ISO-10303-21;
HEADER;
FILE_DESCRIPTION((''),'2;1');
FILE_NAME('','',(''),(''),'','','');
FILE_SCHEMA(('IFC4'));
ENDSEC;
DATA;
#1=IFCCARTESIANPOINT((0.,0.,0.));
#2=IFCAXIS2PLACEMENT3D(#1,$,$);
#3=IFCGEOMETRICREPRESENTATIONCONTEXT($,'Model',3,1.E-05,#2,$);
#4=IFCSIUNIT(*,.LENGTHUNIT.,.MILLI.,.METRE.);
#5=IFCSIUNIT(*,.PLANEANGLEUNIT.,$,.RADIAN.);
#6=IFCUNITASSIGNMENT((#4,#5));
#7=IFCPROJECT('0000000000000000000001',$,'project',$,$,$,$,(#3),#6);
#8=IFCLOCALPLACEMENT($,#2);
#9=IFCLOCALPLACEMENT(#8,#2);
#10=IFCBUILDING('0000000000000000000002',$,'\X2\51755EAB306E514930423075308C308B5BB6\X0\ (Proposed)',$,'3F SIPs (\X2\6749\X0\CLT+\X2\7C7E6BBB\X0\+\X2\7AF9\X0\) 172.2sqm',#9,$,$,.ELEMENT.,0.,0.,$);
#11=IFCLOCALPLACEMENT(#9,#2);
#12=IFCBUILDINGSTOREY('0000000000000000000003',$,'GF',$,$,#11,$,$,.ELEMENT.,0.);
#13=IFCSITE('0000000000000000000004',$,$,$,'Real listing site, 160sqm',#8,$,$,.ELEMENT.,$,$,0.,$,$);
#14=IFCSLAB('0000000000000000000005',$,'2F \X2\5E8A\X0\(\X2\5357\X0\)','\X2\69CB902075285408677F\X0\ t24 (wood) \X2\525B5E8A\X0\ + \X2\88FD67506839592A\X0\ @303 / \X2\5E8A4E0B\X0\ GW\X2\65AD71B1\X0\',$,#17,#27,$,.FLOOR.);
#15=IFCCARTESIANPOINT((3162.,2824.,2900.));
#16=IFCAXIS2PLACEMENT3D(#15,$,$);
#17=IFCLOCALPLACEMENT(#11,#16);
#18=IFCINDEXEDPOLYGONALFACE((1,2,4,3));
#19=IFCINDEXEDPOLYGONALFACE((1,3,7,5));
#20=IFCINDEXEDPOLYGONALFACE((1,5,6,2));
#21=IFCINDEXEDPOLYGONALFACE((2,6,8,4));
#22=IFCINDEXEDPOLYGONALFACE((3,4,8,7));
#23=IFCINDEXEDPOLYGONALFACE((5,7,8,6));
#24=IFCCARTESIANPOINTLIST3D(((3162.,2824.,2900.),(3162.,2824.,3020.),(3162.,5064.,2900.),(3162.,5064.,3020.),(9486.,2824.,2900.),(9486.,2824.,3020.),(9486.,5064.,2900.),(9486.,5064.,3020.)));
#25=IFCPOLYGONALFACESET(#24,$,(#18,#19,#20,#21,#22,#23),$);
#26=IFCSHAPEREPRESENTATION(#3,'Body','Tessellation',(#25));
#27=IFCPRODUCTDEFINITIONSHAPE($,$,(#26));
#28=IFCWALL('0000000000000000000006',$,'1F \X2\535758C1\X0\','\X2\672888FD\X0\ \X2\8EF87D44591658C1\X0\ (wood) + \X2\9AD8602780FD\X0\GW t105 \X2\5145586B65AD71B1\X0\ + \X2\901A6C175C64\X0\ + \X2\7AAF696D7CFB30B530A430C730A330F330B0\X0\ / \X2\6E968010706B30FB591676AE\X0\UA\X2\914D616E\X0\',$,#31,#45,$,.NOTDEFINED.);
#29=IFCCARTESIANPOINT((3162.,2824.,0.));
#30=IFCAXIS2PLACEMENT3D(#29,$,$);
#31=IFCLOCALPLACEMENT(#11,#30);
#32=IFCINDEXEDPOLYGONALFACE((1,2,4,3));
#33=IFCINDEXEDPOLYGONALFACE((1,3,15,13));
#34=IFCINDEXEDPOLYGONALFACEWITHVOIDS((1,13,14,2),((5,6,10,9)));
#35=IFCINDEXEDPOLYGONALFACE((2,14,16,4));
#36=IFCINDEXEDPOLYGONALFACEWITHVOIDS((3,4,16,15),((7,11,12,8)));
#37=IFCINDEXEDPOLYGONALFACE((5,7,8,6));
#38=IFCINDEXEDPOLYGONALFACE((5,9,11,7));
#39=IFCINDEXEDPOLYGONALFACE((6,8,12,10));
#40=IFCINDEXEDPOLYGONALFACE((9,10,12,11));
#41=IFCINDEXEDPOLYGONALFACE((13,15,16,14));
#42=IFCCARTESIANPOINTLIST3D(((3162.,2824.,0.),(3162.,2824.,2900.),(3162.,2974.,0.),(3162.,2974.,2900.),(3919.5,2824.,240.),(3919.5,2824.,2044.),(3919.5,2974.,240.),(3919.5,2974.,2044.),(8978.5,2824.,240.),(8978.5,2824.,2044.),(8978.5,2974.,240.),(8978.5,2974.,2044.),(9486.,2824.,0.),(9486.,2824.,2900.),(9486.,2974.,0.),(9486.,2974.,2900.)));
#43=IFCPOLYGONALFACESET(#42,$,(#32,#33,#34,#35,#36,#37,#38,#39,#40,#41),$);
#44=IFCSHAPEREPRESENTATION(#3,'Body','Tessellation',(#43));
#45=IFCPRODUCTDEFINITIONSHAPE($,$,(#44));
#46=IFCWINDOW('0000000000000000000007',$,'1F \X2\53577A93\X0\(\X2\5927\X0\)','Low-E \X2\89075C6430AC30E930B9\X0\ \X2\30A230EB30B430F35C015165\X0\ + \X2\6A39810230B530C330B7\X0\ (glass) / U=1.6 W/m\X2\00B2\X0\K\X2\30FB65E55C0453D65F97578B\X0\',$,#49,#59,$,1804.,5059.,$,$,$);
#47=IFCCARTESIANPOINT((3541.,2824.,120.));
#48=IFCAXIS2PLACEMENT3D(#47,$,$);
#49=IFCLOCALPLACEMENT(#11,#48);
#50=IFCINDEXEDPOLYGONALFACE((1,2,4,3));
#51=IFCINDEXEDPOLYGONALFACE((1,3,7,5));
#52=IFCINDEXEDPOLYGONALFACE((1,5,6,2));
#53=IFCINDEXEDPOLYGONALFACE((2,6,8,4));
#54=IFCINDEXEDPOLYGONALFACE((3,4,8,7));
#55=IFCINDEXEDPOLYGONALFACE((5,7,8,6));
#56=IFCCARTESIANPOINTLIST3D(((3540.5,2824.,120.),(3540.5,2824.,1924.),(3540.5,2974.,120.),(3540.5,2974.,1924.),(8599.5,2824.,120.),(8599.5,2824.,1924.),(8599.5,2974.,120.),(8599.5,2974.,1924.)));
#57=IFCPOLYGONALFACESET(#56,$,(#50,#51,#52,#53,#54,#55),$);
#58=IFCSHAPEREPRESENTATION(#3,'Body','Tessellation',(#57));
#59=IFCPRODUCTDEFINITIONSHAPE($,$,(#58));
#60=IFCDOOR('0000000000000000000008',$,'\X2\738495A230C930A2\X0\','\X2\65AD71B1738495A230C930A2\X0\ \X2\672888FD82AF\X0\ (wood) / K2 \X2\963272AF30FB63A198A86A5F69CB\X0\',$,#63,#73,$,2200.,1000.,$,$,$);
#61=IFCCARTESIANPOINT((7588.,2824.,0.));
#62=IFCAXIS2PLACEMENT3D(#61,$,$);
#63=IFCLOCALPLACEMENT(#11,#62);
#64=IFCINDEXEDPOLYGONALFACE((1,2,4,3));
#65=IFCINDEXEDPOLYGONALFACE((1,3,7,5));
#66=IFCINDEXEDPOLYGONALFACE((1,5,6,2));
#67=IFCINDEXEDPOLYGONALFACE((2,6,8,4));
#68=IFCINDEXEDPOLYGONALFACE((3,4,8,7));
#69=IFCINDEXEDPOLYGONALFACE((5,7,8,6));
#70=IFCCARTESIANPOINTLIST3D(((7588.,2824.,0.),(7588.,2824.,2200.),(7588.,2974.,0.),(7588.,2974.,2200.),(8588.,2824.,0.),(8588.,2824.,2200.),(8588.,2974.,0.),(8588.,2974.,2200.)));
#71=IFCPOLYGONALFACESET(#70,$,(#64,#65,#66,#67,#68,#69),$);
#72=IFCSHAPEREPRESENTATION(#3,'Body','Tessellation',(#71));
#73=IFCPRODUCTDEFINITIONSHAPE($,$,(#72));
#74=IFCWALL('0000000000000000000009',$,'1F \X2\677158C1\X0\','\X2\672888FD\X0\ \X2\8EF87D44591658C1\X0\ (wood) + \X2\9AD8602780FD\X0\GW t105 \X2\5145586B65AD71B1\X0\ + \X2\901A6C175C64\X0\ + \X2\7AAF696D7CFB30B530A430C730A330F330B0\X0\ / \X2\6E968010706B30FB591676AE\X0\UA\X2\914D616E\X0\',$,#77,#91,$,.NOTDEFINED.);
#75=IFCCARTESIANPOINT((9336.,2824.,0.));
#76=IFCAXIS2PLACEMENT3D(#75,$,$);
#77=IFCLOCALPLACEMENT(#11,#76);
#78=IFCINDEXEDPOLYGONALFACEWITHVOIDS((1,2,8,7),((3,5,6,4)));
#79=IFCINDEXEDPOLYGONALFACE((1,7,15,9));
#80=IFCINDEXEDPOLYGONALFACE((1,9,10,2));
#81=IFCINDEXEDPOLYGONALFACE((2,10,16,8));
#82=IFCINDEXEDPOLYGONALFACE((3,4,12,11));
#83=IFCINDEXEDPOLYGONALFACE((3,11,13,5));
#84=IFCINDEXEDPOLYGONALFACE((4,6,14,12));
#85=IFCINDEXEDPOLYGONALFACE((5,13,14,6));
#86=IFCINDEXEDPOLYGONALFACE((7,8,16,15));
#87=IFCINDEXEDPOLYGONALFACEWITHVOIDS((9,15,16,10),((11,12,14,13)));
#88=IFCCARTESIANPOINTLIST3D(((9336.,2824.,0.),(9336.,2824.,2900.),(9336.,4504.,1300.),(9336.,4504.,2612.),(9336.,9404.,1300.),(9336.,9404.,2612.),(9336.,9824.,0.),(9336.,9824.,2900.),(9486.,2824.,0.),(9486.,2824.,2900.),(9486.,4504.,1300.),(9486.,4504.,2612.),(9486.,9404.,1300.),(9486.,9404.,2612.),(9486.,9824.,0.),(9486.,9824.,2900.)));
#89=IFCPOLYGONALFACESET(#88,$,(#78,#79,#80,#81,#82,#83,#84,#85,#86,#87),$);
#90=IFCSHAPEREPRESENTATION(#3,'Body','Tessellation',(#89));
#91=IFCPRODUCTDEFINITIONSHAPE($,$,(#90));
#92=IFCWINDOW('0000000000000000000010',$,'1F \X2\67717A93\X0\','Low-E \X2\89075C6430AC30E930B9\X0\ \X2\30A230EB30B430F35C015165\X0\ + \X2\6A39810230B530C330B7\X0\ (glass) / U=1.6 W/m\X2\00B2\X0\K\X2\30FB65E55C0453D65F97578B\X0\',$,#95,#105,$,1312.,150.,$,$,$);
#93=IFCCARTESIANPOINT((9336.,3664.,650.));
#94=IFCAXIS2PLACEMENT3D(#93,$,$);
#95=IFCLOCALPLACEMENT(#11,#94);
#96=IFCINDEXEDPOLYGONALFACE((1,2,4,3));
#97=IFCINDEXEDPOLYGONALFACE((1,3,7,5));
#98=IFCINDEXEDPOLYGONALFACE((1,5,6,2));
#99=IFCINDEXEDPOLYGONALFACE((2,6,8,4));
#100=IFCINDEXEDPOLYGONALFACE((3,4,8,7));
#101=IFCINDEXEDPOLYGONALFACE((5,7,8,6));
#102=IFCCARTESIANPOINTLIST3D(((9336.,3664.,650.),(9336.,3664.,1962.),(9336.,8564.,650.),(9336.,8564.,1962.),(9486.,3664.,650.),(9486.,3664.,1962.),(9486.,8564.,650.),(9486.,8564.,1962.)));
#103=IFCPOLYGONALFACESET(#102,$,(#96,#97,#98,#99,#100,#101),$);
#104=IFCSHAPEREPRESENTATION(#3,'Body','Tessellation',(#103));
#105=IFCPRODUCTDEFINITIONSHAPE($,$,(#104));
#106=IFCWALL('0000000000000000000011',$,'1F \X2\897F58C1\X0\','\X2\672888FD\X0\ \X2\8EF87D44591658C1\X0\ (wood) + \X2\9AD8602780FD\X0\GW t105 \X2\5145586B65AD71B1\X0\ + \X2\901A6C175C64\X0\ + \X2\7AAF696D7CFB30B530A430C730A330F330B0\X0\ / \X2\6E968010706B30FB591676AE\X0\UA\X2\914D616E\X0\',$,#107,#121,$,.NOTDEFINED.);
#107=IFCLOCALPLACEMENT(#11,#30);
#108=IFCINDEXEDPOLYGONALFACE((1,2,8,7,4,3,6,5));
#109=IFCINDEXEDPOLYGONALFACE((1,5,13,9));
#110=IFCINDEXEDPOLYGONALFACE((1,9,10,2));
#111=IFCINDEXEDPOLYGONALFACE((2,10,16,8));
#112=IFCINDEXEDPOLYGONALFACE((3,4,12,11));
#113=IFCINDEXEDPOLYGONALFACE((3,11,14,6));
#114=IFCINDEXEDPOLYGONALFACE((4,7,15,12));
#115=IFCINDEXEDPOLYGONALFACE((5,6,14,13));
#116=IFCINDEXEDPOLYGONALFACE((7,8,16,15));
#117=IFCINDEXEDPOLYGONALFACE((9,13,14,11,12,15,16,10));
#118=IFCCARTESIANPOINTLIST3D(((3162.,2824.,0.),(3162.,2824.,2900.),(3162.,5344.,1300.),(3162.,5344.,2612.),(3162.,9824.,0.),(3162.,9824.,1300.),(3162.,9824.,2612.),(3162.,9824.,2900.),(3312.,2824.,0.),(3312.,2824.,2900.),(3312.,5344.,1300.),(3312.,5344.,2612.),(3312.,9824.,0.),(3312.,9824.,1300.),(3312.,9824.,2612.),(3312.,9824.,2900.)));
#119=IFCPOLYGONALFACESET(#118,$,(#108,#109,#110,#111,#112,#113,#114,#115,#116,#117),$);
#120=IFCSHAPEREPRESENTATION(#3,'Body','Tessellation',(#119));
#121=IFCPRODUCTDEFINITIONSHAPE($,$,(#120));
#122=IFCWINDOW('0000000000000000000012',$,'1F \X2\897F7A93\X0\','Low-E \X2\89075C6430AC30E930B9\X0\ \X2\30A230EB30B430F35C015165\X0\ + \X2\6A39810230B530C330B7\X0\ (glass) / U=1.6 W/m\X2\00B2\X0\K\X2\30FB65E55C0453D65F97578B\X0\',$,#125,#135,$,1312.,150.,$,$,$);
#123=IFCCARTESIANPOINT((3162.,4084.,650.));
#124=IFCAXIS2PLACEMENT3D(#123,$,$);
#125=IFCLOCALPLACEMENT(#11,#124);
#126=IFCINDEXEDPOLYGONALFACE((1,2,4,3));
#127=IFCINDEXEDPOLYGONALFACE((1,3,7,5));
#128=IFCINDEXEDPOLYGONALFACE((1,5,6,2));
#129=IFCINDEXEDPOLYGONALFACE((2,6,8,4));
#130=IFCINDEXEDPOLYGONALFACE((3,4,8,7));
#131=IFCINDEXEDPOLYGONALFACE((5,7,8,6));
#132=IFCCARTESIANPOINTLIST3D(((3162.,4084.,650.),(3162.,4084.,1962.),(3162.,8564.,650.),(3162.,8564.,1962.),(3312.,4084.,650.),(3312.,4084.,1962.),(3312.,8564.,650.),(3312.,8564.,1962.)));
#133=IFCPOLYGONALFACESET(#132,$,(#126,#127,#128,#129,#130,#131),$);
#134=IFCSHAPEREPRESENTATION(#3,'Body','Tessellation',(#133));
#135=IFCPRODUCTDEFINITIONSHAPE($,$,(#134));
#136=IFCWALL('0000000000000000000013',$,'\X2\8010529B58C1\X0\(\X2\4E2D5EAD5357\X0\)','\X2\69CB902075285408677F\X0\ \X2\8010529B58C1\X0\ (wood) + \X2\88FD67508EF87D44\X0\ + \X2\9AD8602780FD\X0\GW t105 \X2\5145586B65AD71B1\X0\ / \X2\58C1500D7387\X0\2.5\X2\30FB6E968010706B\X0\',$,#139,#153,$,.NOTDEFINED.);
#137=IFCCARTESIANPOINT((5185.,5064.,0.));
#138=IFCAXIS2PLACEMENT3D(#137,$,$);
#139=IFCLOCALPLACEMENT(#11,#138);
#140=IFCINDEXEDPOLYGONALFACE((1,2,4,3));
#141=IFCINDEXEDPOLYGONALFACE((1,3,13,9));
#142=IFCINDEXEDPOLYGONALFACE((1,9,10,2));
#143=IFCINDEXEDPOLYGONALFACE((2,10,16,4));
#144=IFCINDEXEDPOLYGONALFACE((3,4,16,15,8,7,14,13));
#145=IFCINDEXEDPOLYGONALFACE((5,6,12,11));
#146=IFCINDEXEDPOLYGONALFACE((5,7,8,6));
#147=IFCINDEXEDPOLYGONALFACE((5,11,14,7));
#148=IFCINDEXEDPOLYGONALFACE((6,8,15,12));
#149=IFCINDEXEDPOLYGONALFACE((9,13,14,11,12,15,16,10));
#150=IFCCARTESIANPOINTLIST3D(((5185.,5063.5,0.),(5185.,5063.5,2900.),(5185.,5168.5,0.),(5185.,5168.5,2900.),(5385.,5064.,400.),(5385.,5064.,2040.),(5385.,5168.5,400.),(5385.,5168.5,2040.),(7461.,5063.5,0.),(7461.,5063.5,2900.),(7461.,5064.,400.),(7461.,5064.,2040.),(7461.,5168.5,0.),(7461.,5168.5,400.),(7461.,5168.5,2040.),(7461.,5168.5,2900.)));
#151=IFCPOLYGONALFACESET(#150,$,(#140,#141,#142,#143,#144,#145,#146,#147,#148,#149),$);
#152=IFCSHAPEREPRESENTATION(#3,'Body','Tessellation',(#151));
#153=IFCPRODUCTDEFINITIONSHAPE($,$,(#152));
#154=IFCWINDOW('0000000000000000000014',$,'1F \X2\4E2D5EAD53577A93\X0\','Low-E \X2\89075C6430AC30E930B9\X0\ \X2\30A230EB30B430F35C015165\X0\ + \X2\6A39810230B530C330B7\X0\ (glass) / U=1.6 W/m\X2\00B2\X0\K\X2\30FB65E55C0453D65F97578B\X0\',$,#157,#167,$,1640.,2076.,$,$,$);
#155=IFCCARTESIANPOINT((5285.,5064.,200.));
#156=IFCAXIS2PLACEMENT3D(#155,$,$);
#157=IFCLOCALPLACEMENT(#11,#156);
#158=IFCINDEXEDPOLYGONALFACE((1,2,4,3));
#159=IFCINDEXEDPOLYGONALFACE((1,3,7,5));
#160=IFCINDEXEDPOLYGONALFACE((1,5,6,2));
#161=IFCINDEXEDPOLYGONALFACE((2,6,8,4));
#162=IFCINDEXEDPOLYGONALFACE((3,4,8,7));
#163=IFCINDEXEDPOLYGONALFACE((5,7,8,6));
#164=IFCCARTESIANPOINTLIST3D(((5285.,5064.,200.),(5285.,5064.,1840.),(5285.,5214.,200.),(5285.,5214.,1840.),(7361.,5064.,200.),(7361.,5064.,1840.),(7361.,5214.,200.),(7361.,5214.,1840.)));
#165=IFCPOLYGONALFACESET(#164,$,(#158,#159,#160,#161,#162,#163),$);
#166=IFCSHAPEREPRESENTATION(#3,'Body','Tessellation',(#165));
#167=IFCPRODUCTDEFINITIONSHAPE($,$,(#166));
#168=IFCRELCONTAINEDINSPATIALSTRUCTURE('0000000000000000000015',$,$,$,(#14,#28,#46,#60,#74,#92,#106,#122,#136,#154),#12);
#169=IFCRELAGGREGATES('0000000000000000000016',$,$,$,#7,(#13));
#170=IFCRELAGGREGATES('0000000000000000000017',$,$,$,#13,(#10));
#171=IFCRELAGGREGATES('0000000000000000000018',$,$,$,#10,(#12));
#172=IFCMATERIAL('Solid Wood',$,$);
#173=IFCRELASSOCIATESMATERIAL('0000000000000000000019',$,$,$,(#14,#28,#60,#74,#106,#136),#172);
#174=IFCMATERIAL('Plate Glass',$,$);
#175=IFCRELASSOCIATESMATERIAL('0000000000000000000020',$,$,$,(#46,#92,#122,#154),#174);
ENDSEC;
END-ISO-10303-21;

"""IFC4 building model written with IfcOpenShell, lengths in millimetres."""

from ifc_helpers import new_model, si_unit, frame, frame_2d, origin, place, context, project, spatial, rectangle, extrude, material, element, fill, save


model = new_model("IFC4")

# Units and contexts
model_context = context("Model", 3, precision=1e-05, world=origin())
ifc_project = project(units=[si_unit("LENGTHUNIT", "METRE", prefix="MILLI"), si_unit("PLANEANGLEUNIT", "RADIAN")], contexts=[model_context])

# Site, building, storey
site_placement = place(None, origin())
site = spatial("IfcSite", under=ifc_project, at=site_placement, ObjectType="Real listing site, 160sqm", CompositionType="ELEMENT", RefElevation=0.0)
building_placement = place(site_placement, origin())
building = spatial("IfcBuilding", under=site, at=building_placement, Name="兵庫の光あふれる家 (Proposed)", ObjectType="3F SIPs (杉CLT+籾殻+竹) 172.2sqm", CompositionType="ELEMENT", ElevationOfRefHeight=0.0, ElevationOfTerrain=0.0)
storey_placement = place(building_placement, origin())
storey = spatial("IfcBuildingStorey", under=building, at=storey_placement, Name="GF", CompositionType="ELEMENT", Elevation=0.0)

# Slab
ifc_material_1 = material(Name="Solid Wood")
slab_1_placement = place(storey_placement, frame((3162.0, 2824.0, 2900.0)))
element("IfcSlab", 1, at=slab_1_placement, inside=storey, material=ifc_material_1, Name="2F 床(南)", Description="構造用合板 t24 (wood) 剛床 + 製材根太 @303 / 床下 GW断熱", PredefinedType="FLOOR", context=model_context, shape_type="SweptSolid", body=[
    extrude(rectangle(XDim=6324.0, YDim=2240.0, at=frame_2d((3162.0, 1120.0))), frame((3162.0, 2824.0, 2900.0)), (0.0, 0.0, 1.0), 120.0),
])

# Wall, openings, window, door
wall_1_placement = place(storey_placement, frame((3162.0, 2824.0, 0.0)))
wall_1 = element("IfcWall", 2, at=wall_1_placement, inside=storey, material=ifc_material_1, Name="1F 南壁", Description="木製 軸組外壁 (wood) + 高性能GW t105 充填断熱 + 通気層 + 窯業系サイディング / 準耐火・外皮UA配慮", PredefinedType="NOTDEFINED", context=model_context, shape_type="SweptSolid", body=[
    extrude(rectangle(XDim=6324.0, YDim=150.0, at=frame_2d((3162.0, 75.0))), frame((3162.0, 2824.0, 0.0)), (0.0, 0.0, 1.0), 2900.0),
])
opening_1_placement = place(storey_placement, frame((3541.0, 2824.0, 120.0)))
opening_1 = element("IfcOpeningElement", 3, at=opening_1_placement, cuts=wall_1, PredefinedType="NOTDEFINED", context=model_context, shape_type="SweptSolid", body=[
    extrude(rectangle(XDim=5059.0, YDim=150.0, at=frame_2d((2529.0, 75.0))), frame((3541.0, 2824.0, 120.0)), (0.0, 0.0, 1.0), 1804.0),
])
opening_2_placement = place(storey_placement, frame((7588.0, 2824.0, 0.0)))
opening_2 = element("IfcOpeningElement", 4, at=opening_2_placement, cuts=wall_1, PredefinedType="NOTDEFINED", context=model_context, shape_type="SweptSolid", body=[
    extrude(rectangle(XDim=1000.0, YDim=150.0, at=frame_2d((500.0, 75.0))), frame((7588.0, 2824.0, 0.0)), (0.0, 0.0, 1.0), 2200.0),
])
ifc_material_2 = material(Name="Plate Glass")
window_1_placement = place(storey_placement, frame((3541.0, 2824.0, 120.0)))
window_1 = element("IfcWindow", 5, at=window_1_placement, inside=storey, material=ifc_material_2, Name="1F 南窓(大)", Description="Low-E 複層ガラス アルゴン封入 + 樹脂サッシ (glass) / U=1.6 W/m²K・日射取得型", OverallHeight=1804.0, OverallWidth=5059.0, context=model_context, shape_type="SweptSolid", body=[
    extrude(rectangle(XDim=5059.0, YDim=150.0, at=frame_2d((2529.0, 75.0))), frame((3541.0, 2824.0, 120.0)), (0.0, 0.0, 1.0), 1804.0),
])
fill(opening_1, window_1)
door_placement = place(storey_placement, frame((7588.0, 2824.0, 0.0)))
door = element("IfcDoor", 6, at=door_placement, inside=storey, material=ifc_material_1, Name="玄関ドア", Description="断熱玄関ドア 木製芯 (wood) / K2 防犯・採風機構", OverallHeight=2200.0, OverallWidth=1000.0, context=model_context, shape_type="SweptSolid", body=[
    extrude(rectangle(XDim=1000.0, YDim=150.0, at=frame_2d((500.0, 75.0))), frame((7588.0, 2824.0, 0.0)), (0.0, 0.0, 1.0), 2200.0),
])
fill(opening_2, door)

# Walls, openings, windows
wall_2_placement = place(storey_placement, frame((9336.0, 2824.0, 0.0)))
wall_2 = element("IfcWall", 7, at=wall_2_placement, inside=storey, material=ifc_material_1, Name="1F 東壁", Description="木製 軸組外壁 (wood) + 高性能GW t105 充填断熱 + 通気層 + 窯業系サイディング / 準耐火・外皮UA配慮", PredefinedType="NOTDEFINED", context=model_context, shape_type="SweptSolid", body=[
    extrude(rectangle(XDim=150.0, YDim=7000.0, at=frame_2d((75.0, 3500.0))), frame((9336.0, 2824.0, 0.0)), (0.0, 0.0, 1.0), 2900.0),
])
opening_3_placement = place(storey_placement, frame((9336.0, 3664.0, 650.0)))
opening_3 = element("IfcOpeningElement", 8, at=opening_3_placement, cuts=wall_2, PredefinedType="NOTDEFINED", context=model_context, shape_type="SweptSolid", body=[
    extrude(rectangle(XDim=150.0, YDim=4900.0, at=frame_2d((75.0, 2450.0))), frame((9336.0, 3664.0, 650.0)), (0.0, 0.0, 1.0), 1312.0),
])
window_2_placement = place(storey_placement, frame((9336.0, 3664.0, 650.0)))
window_2 = element("IfcWindow", 9, at=window_2_placement, inside=storey, material=ifc_material_2, Name="1F 東窓", Description="Low-E 複層ガラス アルゴン封入 + 樹脂サッシ (glass) / U=1.6 W/m²K・日射取得型", OverallHeight=1312.0, OverallWidth=150.0, context=model_context, shape_type="SweptSolid", body=[
    extrude(rectangle(XDim=150.0, YDim=4900.0, at=frame_2d((75.0, 2450.0))), frame((9336.0, 3664.0, 650.0)), (0.0, 0.0, 1.0), 1312.0),
])
fill(opening_3, window_2)
wall_3_placement = place(storey_placement, frame((3162.0, 2824.0, 0.0)))
wall_3 = element("IfcWall", 10, at=wall_3_placement, inside=storey, material=ifc_material_1, Name="1F 西壁", Description="木製 軸組外壁 (wood) + 高性能GW t105 充填断熱 + 通気層 + 窯業系サイディング / 準耐火・外皮UA配慮", PredefinedType="NOTDEFINED", context=model_context, shape_type="SweptSolid", body=[
    extrude(rectangle(XDim=150.0, YDim=7000.0, at=frame_2d((75.0, 3500.0))), frame((3162.0, 2824.0, 0.0)), (0.0, 0.0, 1.0), 2900.0),
])
opening_4_placement = place(storey_placement, frame((3162.0, 4084.0, 650.0)))
opening_4 = element("IfcOpeningElement", 11, at=opening_4_placement, cuts=wall_3, PredefinedType="NOTDEFINED", context=model_context, shape_type="SweptSolid", body=[
    extrude(rectangle(XDim=150.0, YDim=4480.0, at=frame_2d((75.0, 2240.0))), frame((3162.0, 4084.0, 650.0)), (0.0, 0.0, 1.0), 1312.0),
])
window_3_placement = place(storey_placement, frame((3162.0, 4084.0, 650.0)))
window_3 = element("IfcWindow", 12, at=window_3_placement, inside=storey, material=ifc_material_2, Name="1F 西窓", Description="Low-E 複層ガラス アルゴン封入 + 樹脂サッシ (glass) / U=1.6 W/m²K・日射取得型", OverallHeight=1312.0, OverallWidth=150.0, context=model_context, shape_type="SweptSolid", body=[
    extrude(rectangle(XDim=150.0, YDim=4480.0, at=frame_2d((75.0, 2240.0))), frame((3162.0, 4084.0, 650.0)), (0.0, 0.0, 1.0), 1312.0),
])
fill(opening_4, window_3)
wall_4_placement = place(storey_placement, frame((5185.0, 5064.0, 0.0)))
wall_4 = element("IfcWall", 13, at=wall_4_placement, inside=storey, material=ifc_material_1, Name="耐力壁(中庭南)", Description="構造用合板 耐力壁 (wood) + 製材軸組 + 高性能GW t105 充填断熱 / 壁倍率2.5・準耐火", PredefinedType="NOTDEFINED", context=model_context, shape_type="SweptSolid", body=[
    extrude(rectangle(XDim=2276.0, YDim=105.0, at=frame_2d((1138.0, 52.0))), frame((5185.0, 5064.0, 0.0)), (0.0, 0.0, 1.0), 2900.0),
])
opening_5_placement = place(storey_placement, frame((5285.0, 5064.0, 200.0)))
opening_5 = element("IfcOpeningElement", 14, at=opening_5_placement, cuts=wall_4, PredefinedType="NOTDEFINED", context=model_context, shape_type="SweptSolid", body=[
    extrude(rectangle(XDim=2076.0, YDim=150.0, at=frame_2d((1038.0, 75.0))), frame((5285.0, 5064.0, 200.0)), (0.0, 0.0, 1.0), 1640.0),
])
window_4_placement = place(storey_placement, frame((5285.0, 5064.0, 200.0)))
window_4 = element("IfcWindow", 15, at=window_4_placement, inside=storey, material=ifc_material_2, Name="1F 中庭南窓", Description="Low-E 複層ガラス アルゴン封入 + 樹脂サッシ (glass) / U=1.6 W/m²K・日射取得型", OverallHeight=1640.0, OverallWidth=2076.0, context=model_context, shape_type="SweptSolid", body=[
    extrude(rectangle(XDim=2076.0, YDim=150.0, at=frame_2d((1038.0, 75.0))), frame((5285.0, 5064.0, 200.0)), (0.0, 0.0, 1.0), 1640.0),
])
fill(opening_5, window_4)

save(model, "model.ifc")
